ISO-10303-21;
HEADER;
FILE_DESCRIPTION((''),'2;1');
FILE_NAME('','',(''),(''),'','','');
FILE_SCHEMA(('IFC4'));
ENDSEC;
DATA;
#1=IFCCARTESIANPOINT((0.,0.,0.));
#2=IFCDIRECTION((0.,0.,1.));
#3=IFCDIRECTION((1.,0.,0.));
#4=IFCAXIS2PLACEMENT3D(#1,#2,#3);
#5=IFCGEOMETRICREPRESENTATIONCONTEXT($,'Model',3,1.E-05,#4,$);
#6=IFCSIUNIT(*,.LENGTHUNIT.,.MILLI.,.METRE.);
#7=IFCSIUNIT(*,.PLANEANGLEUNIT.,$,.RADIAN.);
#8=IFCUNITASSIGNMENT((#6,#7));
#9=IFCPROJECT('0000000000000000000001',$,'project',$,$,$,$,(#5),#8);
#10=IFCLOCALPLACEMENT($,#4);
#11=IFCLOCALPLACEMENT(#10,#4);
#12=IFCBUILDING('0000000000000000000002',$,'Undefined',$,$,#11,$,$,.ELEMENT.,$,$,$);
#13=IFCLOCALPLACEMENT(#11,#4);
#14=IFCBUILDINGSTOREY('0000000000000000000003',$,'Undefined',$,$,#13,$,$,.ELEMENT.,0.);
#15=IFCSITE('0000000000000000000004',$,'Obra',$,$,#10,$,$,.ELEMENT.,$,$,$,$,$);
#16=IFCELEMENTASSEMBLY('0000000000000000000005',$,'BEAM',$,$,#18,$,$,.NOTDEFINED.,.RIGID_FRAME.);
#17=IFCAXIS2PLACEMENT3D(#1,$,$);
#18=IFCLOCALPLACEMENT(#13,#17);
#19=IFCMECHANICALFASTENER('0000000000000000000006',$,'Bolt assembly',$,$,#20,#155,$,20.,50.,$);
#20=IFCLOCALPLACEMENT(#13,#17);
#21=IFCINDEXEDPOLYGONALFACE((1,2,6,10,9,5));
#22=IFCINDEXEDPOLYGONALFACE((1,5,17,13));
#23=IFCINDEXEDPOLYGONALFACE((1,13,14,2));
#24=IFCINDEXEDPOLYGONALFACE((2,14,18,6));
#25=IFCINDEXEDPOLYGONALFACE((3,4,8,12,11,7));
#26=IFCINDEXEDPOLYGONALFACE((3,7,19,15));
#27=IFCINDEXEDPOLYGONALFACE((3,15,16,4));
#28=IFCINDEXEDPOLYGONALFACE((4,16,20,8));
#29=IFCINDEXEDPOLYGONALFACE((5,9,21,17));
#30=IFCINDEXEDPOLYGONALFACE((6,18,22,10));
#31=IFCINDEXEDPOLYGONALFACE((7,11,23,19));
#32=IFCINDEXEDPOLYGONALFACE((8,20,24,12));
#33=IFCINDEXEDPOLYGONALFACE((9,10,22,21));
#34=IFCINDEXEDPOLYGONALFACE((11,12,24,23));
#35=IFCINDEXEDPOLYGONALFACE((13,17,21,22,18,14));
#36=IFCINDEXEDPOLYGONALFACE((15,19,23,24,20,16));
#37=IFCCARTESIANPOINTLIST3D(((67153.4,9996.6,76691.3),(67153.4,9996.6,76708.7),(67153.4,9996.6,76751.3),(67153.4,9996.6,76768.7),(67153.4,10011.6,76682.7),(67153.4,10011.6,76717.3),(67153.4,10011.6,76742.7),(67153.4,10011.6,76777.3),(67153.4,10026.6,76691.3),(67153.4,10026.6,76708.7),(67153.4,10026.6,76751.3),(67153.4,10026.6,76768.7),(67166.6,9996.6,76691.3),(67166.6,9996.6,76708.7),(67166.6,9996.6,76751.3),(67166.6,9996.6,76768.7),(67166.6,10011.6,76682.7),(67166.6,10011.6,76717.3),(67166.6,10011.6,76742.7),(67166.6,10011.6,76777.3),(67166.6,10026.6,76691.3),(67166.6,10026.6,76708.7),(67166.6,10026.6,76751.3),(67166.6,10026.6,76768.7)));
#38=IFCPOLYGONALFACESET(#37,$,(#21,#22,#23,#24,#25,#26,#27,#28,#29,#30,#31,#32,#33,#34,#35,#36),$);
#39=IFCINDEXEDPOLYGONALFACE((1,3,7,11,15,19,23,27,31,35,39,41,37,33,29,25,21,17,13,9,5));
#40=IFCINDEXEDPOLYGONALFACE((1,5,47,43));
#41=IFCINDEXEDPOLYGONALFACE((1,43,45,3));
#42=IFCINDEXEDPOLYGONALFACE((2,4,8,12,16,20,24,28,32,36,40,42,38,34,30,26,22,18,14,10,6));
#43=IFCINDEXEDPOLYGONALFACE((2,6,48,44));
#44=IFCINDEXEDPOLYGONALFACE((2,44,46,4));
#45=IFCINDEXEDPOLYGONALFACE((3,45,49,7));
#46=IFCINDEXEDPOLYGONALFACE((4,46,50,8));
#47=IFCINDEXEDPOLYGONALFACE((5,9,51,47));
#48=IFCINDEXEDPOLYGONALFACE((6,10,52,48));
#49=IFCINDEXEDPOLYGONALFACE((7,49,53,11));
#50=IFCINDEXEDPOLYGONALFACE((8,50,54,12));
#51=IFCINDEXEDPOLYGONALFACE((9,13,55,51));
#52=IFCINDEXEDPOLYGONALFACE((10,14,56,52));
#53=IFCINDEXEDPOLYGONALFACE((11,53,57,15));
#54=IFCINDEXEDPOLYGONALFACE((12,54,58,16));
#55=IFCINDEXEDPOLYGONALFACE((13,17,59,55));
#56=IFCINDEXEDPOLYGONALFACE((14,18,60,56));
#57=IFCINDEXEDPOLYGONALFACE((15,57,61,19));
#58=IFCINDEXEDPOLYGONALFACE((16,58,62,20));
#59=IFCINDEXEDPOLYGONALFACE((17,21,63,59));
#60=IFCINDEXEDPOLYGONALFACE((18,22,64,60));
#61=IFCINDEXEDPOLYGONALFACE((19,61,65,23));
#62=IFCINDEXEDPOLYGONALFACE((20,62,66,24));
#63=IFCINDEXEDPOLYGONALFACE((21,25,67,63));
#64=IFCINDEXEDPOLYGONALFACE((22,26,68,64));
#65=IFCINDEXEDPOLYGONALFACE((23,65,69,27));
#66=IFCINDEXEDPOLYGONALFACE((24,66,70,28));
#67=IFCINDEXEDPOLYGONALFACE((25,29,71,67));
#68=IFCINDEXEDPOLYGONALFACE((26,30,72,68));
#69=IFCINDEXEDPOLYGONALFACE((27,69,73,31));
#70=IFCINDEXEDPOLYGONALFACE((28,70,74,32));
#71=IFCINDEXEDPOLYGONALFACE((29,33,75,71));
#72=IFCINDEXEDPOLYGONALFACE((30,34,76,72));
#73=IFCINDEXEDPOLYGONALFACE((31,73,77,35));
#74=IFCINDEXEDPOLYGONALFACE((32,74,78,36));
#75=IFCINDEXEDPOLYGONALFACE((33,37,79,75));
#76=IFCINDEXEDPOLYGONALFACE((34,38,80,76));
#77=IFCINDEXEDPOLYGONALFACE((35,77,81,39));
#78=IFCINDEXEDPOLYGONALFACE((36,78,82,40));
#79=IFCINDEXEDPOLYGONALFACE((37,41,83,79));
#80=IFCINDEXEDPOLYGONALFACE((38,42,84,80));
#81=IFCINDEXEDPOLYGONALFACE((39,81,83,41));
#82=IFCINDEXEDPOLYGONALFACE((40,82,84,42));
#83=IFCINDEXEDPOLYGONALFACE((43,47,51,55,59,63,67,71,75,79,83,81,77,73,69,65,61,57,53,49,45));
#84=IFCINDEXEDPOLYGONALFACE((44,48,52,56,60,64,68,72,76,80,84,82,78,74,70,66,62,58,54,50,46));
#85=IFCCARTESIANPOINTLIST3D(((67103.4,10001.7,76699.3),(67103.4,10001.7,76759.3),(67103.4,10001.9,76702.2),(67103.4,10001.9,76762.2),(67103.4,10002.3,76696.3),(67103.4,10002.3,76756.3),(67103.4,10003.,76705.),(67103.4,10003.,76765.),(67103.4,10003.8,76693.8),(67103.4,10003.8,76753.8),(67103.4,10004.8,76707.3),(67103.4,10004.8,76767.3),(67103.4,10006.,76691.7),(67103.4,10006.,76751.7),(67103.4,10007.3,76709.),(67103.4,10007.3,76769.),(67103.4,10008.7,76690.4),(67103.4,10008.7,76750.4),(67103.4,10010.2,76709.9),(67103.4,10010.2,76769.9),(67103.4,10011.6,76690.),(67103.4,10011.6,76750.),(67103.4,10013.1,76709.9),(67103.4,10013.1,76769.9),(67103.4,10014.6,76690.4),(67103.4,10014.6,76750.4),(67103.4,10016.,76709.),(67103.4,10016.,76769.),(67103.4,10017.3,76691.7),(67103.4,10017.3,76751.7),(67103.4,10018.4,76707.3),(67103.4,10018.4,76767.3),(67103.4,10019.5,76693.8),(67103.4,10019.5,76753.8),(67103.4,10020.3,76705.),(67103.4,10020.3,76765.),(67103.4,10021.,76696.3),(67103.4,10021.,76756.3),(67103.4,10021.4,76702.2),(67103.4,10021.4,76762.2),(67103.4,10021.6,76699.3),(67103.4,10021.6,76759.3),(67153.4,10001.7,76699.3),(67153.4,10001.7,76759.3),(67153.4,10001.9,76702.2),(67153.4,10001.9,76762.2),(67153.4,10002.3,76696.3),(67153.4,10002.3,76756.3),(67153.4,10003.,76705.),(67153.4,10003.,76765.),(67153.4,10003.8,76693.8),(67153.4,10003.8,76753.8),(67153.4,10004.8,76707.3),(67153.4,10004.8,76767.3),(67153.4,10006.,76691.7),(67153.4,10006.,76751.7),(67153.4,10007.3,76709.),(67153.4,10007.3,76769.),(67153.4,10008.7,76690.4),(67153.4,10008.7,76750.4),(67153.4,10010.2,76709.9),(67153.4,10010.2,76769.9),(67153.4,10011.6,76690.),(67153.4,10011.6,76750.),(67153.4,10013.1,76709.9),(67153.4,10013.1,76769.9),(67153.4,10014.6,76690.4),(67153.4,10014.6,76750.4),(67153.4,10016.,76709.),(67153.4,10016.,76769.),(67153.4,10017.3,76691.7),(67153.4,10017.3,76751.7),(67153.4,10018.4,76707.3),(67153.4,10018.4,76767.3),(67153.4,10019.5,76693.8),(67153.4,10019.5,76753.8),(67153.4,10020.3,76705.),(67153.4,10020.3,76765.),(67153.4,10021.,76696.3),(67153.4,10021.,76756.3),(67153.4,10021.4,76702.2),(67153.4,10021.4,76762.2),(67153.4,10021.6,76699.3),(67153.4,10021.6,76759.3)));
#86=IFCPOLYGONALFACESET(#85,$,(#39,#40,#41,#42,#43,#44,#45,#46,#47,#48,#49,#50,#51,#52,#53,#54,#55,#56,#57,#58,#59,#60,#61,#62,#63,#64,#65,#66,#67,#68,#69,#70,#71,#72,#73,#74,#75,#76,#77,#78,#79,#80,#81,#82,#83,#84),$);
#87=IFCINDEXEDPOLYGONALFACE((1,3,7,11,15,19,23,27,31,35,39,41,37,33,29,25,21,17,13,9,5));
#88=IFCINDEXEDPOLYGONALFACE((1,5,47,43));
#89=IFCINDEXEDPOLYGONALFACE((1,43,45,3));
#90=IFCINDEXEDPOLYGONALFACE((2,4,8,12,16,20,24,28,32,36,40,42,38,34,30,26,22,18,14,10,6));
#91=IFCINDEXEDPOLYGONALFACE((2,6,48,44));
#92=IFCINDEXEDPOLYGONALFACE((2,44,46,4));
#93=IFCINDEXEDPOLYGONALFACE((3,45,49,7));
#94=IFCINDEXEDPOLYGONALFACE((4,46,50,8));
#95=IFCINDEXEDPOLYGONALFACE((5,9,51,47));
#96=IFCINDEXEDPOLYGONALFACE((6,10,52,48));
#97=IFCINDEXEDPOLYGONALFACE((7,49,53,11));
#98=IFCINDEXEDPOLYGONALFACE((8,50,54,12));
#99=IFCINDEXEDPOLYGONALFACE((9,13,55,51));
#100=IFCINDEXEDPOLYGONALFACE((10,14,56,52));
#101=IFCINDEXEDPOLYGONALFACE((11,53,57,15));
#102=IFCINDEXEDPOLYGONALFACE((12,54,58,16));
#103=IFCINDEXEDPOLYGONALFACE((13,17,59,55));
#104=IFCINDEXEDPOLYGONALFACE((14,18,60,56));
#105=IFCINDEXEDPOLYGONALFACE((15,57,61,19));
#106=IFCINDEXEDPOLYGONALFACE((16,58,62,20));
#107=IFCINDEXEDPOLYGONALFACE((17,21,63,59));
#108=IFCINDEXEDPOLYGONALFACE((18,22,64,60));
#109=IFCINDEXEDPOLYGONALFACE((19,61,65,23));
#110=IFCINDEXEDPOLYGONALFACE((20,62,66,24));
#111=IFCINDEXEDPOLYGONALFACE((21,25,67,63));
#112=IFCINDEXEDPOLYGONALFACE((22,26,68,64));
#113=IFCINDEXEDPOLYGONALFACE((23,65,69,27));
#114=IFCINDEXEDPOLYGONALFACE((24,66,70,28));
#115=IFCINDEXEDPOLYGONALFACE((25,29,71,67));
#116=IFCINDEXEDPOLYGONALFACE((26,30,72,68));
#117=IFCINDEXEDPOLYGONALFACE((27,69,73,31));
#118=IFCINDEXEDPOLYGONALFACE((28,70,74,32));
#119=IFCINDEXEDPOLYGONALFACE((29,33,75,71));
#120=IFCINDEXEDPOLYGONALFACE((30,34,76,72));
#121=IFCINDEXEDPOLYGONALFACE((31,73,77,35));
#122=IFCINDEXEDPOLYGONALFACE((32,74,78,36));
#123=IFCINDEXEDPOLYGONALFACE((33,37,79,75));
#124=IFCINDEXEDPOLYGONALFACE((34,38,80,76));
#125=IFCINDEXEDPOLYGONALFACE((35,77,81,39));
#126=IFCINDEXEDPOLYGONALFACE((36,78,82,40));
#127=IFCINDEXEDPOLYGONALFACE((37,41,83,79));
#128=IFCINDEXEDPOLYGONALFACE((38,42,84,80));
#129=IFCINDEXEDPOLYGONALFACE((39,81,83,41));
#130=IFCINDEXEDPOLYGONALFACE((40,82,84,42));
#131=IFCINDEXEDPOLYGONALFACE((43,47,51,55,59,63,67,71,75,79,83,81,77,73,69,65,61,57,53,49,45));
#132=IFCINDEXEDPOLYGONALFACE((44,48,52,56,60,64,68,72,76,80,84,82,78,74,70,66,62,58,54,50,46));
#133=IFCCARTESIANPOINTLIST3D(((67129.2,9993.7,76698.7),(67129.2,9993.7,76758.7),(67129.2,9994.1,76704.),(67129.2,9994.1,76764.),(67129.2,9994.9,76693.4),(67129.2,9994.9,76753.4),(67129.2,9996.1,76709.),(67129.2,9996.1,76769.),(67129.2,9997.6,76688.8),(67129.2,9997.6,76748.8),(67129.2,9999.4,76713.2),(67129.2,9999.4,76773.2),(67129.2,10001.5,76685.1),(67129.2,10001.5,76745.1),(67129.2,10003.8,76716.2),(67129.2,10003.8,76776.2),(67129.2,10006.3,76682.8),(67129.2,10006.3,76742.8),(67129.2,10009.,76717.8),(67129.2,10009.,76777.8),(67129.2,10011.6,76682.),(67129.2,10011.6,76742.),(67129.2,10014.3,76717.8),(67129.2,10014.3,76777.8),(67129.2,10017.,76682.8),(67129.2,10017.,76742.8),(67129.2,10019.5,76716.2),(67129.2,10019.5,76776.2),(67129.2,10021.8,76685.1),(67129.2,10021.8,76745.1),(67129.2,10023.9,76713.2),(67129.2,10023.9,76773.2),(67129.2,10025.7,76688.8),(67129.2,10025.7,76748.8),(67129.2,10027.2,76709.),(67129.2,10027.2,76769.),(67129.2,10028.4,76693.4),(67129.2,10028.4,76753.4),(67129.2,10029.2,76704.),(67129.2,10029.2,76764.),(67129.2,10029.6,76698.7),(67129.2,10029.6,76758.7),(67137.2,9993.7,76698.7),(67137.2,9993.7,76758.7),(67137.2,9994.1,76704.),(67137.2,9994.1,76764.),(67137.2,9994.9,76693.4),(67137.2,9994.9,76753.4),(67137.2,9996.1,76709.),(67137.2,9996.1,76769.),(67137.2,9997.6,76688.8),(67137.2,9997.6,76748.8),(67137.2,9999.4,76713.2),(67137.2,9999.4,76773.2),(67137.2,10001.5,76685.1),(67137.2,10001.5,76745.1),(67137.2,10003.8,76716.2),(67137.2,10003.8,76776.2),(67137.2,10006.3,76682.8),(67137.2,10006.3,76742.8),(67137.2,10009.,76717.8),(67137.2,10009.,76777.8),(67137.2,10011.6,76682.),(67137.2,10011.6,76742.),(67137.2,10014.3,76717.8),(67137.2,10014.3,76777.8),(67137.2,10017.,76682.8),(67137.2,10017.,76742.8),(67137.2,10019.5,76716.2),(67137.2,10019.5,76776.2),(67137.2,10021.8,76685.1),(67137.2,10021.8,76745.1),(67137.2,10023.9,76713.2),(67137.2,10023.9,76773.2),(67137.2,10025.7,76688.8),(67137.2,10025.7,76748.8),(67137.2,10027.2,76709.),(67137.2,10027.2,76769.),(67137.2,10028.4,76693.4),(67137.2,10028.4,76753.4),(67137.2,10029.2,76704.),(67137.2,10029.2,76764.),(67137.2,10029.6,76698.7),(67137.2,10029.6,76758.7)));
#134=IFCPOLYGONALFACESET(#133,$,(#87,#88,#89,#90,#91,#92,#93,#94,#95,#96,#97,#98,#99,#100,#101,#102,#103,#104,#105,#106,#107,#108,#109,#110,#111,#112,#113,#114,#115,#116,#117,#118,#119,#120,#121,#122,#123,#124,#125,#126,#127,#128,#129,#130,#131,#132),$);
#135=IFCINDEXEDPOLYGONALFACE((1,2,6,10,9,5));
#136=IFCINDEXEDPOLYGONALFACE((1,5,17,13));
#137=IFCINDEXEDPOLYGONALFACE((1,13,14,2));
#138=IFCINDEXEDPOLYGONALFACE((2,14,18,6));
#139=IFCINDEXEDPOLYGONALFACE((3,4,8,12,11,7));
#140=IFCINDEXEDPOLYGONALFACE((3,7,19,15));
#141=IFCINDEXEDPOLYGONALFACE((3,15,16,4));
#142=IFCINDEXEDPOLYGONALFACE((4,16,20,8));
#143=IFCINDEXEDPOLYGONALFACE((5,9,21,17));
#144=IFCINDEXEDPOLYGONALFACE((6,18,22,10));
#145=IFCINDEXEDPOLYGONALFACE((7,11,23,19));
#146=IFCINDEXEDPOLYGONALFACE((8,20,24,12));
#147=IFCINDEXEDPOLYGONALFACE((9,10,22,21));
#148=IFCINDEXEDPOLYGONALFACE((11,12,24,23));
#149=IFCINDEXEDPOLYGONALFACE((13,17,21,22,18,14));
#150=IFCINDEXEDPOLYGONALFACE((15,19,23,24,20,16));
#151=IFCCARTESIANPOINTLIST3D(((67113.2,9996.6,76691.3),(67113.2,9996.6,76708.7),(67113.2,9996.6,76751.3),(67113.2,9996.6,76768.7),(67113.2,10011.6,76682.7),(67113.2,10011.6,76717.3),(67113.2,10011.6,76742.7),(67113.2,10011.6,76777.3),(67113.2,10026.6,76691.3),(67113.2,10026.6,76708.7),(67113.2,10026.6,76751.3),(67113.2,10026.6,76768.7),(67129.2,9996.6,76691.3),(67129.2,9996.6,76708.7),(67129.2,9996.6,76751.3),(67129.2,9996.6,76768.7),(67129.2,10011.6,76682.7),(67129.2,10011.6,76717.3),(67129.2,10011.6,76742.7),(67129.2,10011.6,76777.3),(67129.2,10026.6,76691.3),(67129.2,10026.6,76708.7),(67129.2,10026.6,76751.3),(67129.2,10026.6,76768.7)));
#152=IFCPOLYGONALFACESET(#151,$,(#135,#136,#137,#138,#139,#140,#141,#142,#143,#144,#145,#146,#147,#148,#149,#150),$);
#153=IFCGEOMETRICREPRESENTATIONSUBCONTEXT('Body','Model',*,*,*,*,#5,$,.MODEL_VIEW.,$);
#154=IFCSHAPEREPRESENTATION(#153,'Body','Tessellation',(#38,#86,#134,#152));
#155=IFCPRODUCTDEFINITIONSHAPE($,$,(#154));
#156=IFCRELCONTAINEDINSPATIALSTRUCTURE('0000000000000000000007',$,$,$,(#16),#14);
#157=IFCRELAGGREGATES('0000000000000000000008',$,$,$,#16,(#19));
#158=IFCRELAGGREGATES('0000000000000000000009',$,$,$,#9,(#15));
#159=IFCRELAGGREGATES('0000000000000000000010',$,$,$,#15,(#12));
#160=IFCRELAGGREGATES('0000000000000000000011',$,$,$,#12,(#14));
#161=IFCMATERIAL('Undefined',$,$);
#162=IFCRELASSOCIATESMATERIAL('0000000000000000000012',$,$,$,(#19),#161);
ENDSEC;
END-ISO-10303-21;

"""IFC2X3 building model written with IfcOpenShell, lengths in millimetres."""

from ifc_helpers import new_model, si_unit, frame, origin_with_axes, origin_2d_with_axis, place, context, subcontext, project, spatial, polyline, circle, outline, extrude, source, transform, mapped, material, element, aggregate, save


model = new_model("IFC2X3")

# Units and contexts
model_context = context("Model", 3, precision=1e-05, world=origin_with_axes())
body_context = subcontext(model_context, "Body", "Model", "MODEL_VIEW")
ifc_project = project(units=[si_unit("LENGTHUNIT", "METRE", prefix="MILLI"), si_unit("PLANEANGLEUNIT", "RADIAN")], contexts=[model_context])

# Site, building, storey
site_placement = place(None, origin_with_axes())
site = spatial("IfcSite", under=ifc_project, at=site_placement, Name="Obra", CompositionType="ELEMENT")
building_placement = place(site_placement, origin_with_axes())
building = spatial("IfcBuilding", under=site, at=building_placement, Name="Undefined", CompositionType="ELEMENT")
storey_placement = place(building_placement, origin_with_axes())
storey = spatial("IfcBuildingStorey", under=building, at=storey_placement, Name="Undefined", CompositionType="ELEMENT", Elevation=0.0)

# Element assembly
assembly_1_placement = place(storey_placement, origin_with_axes())
assembly_1 = element("IfcElementAssembly", 1, at=assembly_1_placement, inside=storey, Name="BEAM", AssemblyPlace="NOTDEFINED", PredefinedType="RIGID_FRAME")

# Mechanical fastener
ifc_material_1 = material(Name="Undefined")
shared_shape_1 = source(origin_with_axes(), body_context, "Body", "SweptSolid", [
    extrude(outline(polyline([(17.3, 0.0), (8.7, 15.0), (-8.7, 15.0), (-17.3, 0.0), (-8.7, -15.0), (8.7, -15.0), (17.3, 0.0)])), frame((0.0, -26.3, 0.0), z_axis=(0.0, 1.0, 0.0), x_axis=(1.0, 0.0, 0.0)), (0.0, 0.0, 1.0), 13.2),
    extrude(circle(Radius=10.0, at=origin_2d_with_axis()), frame((0.0, -13.1, 0.0), z_axis=(0.0, 1.0, 0.0), x_axis=(1.0, 0.0, 0.0)), (0.0, 0.0, 1.0), 50.0),
    extrude(circle(Radius=18.0, at=origin_2d_with_axis()), frame((0.0, 3.1, 0.0), z_axis=(0.0, 1.0, 0.0), x_axis=(1.0, 0.0, 0.0)), (0.0, 0.0, 1.0), 8.0),
    extrude(outline(polyline([(17.3, 0.0), (8.7, 15.0), (-8.7, 15.0), (-17.3, 0.0), (-8.7, -15.0), (8.7, -15.0), (17.3, 0.0)])), frame((0.0, 11.1, 0.0), z_axis=(0.0, 1.0, 0.0), x_axis=(1.0, 0.0, 0.0)), (0.0, 0.0, 1.0), 16.0),
])
mechanical_fastener_1_placement = place(assembly_1_placement, frame((67140.3, 9971.6, 76850.0), z_axis=(0.0, 1.0, 0.0), x_axis=(0.0, 0.0, -1.0)))
mechanical_fastener_1 = element("IfcMechanicalFastener", 2, at=mechanical_fastener_1_placement, material=ifc_material_1, Name="Bolt assembly", NominalDiameter=20.0, NominalLength=50.0, context=body_context, shape_type="MappedRepresentation", body=[
    mapped(shared_shape_1, transform((90.0, 0.0, 40.0))),
    mapped(shared_shape_1, transform((150.0, 0.0, 40.0))),
])
aggregate(assembly_1, [mechanical_fastener_1])

save(model, "model.ifc")
